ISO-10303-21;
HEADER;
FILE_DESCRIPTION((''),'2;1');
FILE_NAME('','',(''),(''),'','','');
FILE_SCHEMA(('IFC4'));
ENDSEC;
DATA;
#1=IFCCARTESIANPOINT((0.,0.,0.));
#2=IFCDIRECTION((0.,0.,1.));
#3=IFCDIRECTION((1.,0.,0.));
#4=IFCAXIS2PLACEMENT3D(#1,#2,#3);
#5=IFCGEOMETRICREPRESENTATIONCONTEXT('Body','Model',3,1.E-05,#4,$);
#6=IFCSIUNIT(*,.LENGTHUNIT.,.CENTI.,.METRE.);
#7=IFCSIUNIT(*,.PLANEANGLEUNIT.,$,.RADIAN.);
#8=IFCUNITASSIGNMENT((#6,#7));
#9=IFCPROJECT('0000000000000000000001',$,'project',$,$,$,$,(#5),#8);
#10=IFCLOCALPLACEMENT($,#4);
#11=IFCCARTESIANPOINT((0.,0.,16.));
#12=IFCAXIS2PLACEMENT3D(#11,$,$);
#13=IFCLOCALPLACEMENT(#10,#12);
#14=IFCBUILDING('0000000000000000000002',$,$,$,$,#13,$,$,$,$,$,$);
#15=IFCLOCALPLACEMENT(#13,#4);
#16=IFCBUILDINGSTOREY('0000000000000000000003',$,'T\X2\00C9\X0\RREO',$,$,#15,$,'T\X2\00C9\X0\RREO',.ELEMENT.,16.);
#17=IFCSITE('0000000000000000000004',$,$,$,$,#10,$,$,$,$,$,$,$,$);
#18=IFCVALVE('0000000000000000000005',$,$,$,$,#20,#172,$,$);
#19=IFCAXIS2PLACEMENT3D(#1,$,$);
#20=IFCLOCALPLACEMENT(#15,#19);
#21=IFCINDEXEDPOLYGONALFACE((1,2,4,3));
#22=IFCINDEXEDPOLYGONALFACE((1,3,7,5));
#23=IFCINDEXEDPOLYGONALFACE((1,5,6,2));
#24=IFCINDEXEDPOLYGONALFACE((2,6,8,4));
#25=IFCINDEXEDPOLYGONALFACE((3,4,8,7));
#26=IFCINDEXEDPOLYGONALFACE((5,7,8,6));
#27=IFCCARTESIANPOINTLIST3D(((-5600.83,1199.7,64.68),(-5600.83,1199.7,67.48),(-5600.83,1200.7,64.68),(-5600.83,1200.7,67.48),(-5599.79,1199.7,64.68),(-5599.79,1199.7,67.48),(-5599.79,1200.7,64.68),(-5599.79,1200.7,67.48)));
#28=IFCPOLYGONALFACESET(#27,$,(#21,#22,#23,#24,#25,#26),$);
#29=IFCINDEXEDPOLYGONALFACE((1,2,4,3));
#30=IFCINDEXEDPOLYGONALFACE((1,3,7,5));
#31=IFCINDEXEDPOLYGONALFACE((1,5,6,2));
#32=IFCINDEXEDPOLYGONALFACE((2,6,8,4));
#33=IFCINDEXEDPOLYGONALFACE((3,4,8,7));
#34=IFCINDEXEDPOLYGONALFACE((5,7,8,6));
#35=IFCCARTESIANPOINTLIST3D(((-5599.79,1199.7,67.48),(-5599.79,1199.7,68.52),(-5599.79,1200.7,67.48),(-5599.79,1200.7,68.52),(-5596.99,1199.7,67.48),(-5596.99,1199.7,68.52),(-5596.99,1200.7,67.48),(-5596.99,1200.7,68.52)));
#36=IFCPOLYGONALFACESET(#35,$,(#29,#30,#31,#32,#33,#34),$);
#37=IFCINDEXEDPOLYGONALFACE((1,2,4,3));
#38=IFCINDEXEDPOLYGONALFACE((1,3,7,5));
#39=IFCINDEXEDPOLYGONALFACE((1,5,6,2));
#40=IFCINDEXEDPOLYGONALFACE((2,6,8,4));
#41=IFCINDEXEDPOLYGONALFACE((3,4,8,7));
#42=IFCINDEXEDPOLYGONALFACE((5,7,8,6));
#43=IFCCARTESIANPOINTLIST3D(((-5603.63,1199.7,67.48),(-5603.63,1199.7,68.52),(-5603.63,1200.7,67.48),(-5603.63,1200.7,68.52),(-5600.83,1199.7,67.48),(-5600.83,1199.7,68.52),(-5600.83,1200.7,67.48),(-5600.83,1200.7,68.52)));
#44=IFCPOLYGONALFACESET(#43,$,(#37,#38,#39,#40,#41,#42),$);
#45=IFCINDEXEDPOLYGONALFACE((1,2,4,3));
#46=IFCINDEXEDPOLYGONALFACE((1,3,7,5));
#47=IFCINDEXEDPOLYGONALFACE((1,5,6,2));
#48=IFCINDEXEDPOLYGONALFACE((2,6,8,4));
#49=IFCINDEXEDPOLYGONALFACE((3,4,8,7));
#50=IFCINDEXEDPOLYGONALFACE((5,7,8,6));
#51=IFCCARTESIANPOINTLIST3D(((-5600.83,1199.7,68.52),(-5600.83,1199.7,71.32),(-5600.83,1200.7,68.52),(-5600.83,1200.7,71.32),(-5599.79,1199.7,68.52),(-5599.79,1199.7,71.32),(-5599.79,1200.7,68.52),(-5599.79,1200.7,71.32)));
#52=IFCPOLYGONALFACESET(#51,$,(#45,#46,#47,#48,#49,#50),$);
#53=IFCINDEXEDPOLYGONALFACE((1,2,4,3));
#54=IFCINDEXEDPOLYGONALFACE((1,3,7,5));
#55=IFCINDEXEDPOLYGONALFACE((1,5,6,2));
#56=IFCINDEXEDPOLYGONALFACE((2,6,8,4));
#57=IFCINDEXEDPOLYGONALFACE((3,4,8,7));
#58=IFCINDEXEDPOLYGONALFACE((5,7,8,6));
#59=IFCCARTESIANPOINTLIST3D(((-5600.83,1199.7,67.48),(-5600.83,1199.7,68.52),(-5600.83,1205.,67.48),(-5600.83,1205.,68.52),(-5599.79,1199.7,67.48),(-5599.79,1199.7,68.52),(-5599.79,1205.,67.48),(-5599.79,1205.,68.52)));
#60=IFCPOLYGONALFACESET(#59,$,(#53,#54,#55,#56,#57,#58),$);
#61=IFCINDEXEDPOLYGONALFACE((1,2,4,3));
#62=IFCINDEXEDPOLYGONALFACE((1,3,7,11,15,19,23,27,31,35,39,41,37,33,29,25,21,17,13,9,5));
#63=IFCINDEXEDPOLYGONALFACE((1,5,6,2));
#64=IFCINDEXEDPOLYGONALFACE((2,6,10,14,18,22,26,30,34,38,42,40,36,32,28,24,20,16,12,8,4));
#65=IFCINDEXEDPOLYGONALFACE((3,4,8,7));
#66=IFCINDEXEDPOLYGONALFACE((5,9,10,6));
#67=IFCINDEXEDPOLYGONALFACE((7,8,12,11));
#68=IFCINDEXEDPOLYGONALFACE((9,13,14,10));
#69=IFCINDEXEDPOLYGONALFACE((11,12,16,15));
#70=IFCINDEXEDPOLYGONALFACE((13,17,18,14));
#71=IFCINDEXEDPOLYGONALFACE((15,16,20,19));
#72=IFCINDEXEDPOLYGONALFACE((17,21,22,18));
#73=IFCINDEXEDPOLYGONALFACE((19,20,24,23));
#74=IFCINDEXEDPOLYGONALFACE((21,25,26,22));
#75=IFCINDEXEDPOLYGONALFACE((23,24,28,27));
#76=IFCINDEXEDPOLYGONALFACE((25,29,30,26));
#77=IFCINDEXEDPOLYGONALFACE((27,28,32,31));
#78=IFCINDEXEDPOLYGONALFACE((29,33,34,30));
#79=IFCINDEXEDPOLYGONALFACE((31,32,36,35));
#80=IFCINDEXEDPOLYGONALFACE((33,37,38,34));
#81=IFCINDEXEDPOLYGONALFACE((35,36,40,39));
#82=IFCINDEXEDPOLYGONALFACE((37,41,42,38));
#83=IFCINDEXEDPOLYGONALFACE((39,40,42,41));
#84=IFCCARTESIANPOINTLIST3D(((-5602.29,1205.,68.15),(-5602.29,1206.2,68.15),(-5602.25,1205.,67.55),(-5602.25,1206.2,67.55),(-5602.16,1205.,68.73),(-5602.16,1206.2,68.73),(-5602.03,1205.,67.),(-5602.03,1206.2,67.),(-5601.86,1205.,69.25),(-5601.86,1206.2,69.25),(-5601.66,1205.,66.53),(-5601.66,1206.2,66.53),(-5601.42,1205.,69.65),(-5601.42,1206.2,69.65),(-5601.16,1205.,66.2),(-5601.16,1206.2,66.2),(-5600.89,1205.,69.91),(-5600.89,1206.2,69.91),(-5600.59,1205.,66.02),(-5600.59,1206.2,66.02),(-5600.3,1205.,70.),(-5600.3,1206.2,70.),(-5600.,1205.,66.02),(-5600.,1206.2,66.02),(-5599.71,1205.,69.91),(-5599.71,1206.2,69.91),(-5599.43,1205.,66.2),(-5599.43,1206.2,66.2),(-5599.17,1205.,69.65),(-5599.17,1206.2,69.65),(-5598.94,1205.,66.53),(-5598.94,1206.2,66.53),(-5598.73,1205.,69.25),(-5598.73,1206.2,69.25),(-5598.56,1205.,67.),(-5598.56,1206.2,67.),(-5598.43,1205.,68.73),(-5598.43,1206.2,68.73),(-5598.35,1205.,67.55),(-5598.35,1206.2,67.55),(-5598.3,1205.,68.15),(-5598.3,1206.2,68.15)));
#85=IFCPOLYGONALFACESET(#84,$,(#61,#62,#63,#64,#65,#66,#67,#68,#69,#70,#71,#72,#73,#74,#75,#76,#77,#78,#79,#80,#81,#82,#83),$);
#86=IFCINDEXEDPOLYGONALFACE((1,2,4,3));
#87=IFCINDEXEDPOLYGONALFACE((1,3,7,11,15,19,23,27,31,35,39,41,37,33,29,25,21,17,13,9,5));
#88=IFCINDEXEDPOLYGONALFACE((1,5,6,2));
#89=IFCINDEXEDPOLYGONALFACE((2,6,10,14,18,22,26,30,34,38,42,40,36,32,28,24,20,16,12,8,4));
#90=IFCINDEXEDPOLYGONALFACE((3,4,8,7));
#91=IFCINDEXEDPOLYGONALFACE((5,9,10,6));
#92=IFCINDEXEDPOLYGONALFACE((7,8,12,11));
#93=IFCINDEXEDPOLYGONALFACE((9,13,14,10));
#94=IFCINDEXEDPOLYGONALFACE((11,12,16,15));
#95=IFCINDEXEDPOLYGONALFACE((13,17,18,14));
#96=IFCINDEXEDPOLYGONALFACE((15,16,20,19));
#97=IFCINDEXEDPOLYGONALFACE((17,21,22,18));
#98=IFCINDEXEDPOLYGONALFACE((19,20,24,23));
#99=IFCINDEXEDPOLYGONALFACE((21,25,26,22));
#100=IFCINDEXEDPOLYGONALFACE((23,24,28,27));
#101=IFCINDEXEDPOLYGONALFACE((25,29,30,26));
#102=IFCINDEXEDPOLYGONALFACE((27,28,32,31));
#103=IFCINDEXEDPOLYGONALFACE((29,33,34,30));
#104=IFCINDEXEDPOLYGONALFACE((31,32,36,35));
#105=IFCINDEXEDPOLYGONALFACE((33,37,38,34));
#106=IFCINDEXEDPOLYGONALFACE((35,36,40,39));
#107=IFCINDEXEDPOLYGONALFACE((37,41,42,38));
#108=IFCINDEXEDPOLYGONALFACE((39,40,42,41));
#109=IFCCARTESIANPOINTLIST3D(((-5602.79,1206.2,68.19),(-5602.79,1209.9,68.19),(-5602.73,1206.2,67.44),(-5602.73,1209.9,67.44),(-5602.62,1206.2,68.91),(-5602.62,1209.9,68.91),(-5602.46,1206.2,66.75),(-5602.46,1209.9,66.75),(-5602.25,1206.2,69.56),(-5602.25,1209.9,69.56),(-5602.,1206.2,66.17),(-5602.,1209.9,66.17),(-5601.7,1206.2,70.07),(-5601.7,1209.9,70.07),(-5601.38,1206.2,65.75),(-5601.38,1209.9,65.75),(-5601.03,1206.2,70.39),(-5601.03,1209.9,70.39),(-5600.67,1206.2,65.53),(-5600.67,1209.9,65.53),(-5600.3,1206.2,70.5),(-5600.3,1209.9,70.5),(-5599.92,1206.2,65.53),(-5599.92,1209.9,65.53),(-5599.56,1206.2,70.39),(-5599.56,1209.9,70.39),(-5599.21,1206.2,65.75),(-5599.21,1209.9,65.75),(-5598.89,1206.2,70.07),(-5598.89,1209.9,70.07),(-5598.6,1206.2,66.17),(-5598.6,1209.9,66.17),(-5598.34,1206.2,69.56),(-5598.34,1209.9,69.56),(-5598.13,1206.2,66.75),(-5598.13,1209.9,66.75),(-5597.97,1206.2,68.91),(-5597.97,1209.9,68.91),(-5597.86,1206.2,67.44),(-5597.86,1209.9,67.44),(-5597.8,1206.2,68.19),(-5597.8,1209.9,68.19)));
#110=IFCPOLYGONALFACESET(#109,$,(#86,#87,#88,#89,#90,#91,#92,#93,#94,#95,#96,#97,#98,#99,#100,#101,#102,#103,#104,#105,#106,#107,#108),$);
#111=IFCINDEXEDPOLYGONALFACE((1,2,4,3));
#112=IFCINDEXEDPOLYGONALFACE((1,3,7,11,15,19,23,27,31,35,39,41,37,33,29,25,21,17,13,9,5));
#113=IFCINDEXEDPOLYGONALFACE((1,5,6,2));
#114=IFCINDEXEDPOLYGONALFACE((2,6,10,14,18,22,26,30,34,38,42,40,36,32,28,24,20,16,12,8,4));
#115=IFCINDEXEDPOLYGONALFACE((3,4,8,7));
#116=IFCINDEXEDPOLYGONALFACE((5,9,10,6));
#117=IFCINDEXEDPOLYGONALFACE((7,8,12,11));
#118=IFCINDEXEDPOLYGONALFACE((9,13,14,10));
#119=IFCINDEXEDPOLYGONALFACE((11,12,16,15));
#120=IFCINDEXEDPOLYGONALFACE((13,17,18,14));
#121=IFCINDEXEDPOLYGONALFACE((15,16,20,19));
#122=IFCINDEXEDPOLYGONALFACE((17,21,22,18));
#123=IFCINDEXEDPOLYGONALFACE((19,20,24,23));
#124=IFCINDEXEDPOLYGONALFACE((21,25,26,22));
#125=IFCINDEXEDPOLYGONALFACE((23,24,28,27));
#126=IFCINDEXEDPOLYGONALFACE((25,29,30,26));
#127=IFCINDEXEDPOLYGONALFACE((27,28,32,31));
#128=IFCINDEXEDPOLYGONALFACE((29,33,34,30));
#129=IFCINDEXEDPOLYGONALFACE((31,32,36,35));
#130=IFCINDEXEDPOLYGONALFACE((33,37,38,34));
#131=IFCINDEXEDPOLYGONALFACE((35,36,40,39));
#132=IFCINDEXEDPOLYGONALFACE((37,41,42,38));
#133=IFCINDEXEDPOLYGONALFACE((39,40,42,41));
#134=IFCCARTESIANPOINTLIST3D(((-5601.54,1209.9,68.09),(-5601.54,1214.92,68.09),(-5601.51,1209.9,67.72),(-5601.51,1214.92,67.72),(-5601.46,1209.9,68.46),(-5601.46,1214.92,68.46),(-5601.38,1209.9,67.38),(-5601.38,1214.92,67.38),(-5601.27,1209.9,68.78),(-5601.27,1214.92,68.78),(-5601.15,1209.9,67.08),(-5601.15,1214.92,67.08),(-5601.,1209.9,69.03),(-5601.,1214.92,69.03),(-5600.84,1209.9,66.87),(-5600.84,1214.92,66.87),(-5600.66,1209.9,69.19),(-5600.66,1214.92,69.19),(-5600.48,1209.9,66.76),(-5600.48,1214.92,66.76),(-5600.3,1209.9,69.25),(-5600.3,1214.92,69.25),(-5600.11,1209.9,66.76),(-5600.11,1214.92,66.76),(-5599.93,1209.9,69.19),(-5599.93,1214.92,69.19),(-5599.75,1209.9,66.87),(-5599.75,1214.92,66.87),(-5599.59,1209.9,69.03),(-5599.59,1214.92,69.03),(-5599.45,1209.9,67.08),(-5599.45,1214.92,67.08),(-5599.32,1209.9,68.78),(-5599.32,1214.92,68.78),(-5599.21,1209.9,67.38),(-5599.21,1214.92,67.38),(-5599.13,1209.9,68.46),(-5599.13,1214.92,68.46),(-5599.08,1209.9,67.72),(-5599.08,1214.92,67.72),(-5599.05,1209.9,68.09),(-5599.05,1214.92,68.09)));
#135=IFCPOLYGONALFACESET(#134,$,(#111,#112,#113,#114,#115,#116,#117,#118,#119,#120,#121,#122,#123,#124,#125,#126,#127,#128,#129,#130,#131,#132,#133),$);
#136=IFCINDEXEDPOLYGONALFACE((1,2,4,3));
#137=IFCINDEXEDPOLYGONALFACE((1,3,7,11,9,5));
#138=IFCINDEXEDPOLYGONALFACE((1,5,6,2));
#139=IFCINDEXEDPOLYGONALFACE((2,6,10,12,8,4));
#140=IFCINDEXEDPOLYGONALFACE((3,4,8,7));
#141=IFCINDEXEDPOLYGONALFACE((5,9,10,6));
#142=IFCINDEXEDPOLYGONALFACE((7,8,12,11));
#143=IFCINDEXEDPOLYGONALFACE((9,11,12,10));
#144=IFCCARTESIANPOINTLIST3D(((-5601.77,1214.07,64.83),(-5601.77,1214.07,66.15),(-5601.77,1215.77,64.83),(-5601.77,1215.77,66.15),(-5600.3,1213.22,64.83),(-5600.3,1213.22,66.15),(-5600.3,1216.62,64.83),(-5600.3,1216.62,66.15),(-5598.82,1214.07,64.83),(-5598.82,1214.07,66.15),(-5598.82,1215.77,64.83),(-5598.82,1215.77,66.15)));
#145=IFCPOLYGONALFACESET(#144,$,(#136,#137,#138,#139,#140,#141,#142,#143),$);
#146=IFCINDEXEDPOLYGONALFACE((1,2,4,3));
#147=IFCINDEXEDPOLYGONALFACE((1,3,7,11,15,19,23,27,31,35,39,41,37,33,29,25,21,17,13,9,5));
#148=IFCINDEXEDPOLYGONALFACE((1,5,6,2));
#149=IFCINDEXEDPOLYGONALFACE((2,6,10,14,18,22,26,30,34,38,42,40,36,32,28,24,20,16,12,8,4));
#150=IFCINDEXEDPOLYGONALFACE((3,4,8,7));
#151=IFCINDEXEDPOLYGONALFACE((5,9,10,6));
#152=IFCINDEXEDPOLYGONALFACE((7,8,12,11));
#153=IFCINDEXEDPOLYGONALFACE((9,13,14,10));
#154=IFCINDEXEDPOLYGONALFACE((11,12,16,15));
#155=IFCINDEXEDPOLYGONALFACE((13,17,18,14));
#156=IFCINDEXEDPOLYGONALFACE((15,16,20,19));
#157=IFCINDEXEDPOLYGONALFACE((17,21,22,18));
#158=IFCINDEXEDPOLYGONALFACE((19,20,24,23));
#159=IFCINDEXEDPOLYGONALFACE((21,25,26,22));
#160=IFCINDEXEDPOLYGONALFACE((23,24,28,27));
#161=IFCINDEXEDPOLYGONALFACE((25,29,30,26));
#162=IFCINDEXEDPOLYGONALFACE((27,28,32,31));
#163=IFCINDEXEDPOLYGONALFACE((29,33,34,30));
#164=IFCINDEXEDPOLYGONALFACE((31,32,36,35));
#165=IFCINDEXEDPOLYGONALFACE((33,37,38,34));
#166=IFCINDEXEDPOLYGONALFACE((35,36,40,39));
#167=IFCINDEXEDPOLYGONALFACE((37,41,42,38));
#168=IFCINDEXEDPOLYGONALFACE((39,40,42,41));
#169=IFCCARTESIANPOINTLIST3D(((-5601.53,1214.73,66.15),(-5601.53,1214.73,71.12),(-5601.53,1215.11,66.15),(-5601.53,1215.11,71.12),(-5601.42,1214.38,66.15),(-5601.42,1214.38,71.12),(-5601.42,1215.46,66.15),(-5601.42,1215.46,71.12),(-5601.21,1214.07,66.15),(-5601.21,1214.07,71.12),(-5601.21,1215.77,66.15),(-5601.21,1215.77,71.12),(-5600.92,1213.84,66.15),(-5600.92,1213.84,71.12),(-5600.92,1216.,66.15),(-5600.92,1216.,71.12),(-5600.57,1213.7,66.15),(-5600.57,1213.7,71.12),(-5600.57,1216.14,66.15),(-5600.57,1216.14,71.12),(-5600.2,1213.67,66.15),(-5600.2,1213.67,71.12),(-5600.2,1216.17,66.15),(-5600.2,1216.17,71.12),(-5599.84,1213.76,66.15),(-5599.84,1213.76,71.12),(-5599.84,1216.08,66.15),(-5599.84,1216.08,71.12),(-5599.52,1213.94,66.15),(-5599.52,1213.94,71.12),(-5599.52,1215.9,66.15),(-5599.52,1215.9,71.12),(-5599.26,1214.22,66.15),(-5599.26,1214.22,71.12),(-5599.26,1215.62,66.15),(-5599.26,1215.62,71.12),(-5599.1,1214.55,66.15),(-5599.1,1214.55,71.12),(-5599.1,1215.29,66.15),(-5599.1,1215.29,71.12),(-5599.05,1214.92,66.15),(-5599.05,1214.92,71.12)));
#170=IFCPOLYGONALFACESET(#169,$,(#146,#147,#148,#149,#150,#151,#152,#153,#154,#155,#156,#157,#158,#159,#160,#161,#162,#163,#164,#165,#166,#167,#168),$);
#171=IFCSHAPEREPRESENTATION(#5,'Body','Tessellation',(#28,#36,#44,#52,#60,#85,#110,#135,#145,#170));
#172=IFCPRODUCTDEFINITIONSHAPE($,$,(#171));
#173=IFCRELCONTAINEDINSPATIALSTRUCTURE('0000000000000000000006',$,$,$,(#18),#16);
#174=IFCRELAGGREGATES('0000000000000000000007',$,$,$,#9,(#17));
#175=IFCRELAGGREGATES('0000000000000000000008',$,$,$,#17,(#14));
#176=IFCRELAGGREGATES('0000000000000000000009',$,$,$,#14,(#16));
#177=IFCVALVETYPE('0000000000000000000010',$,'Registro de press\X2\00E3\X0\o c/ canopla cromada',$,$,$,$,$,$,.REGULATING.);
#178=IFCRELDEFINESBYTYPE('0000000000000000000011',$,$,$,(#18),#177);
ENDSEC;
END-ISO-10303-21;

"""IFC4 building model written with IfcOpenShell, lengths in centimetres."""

from ifc_helpers import new_model, si_unit, frame, origin_with_axes, origin_2d_with_axis, place, context, project, spatial, polyline, rectangle, circle, outline, extrude, source, transform, mapped, type_object, element, save


model = new_model("IFC4")

# Units and contexts
model_context = context("Model", 3, precision=1e-05, world=origin_with_axes(), identifier="Body")
ifc_project = project(units=[si_unit("LENGTHUNIT", "METRE", prefix="CENTI"), si_unit("PLANEANGLEUNIT", "RADIAN")], contexts=[model_context])

# Site, building, storey
site_placement = place(None, origin_with_axes())
site = spatial("IfcSite", under=ifc_project, at=site_placement)
building_placement = place(site_placement, frame((0.0, 0.0, 16.0)))
building = spatial("IfcBuilding", under=site, at=building_placement)
storey_placement = place(building_placement, origin_with_axes())
storey = spatial("IfcBuildingStorey", under=building, at=storey_placement, Name="TÉRREO", LongName="TÉRREO", CompositionType="ELEMENT", Elevation=16.0)

# Valve
valve_type = type_object("IfcValveType", Name="Registro de pressão c/ canopla cromada", PredefinedType="REGULATING")
shared_shape = source(origin_with_axes(), model_context, "Body", "SolidModel", [
    extrude(rectangle(XDim=1.04, YDim=2.8, at=origin_2d_with_axis()), frame((-1.92, 0.01, 14.22), z_axis=(0.0, 0.0, 1.0), x_axis=(0.0, -1.0, 0.0)), (0.0, 0.0, 1.0), 1.0),
    extrude(rectangle(XDim=1.04, YDim=2.8, at=origin_2d_with_axis()), frame((0.0, -1.91, 14.22), z_axis=(0.0, 0.0, 1.0), x_axis=(1.0, 0.0, 0.0)), (0.0, 0.0, 1.0), 1.0),
    extrude(rectangle(XDim=1.04, YDim=2.8, at=origin_2d_with_axis()), frame((0.0, 1.93, 14.22), z_axis=(0.0, 0.0, 1.0), x_axis=(-1.0, 0.0, 0.0)), (0.0, 0.0, 1.0), 1.0),
    extrude(rectangle(XDim=1.04, YDim=2.8, at=origin_2d_with_axis()), frame((1.92, 0.01, 14.22), z_axis=(0.0, 0.0, 1.0), x_axis=(0.0, 1.0, 0.0)), (0.0, 0.0, 1.0), 1.0),
    extrude(rectangle(XDim=1.04, YDim=1.04, at=origin_2d_with_axis()), frame((0.0, 0.01, 9.92), z_axis=(0.0, 0.0, 1.0), x_axis=(0.0, 1.0, 0.0)), (0.0, 0.0, 1.0), 5.3),
    extrude(circle(Radius=2.0, at=origin_2d_with_axis()), frame((0.0, 0.0, 8.72), z_axis=(0.0, 0.0, 1.0), x_axis=(1.0, 0.0, 0.0)), (0.0, 0.0, 1.0), 1.2),
    extrude(circle(Radius=2.5, at=origin_2d_with_axis()), frame((0.0, 0.0, 5.02), z_axis=(0.0, 0.0, 1.0), x_axis=(1.0, 0.0, 0.0)), (0.0, 0.0, 1.0), 3.7),
    extrude(circle(Radius=1.25, at=origin_2d_with_axis()), origin_with_axes(), (0.0, 0.0, 1.0), 5.02),
    extrude(outline(polyline([(-0.85, -1.47), (0.85, -1.47), (1.7, 0.0), (0.85, 1.47), (-0.85, 1.47), (-1.7, 0.0), (-0.85, -1.47)])), frame((-3.17, 0.0, 0.0), z_axis=(1.0, 0.0, 0.0), x_axis=(0.0, 0.0, -1.0)), (0.0, 0.0, 1.0), 1.32),
    extrude(circle(Radius=1.25, at=origin_2d_with_axis()), frame((-1.85, 0.0, 0.0), z_axis=(1.0, 0.0, 0.0), x_axis=(0.0, -1.0, 0.0)), (0.0, 0.0, 1.0), 4.97),
])
for number, where, z_axis, x_axis in (
    (1, (-5600.3, 1214.92, 68.0), (0.0, -1.0, 0.0), (0.0, 0.0, 1.0)),
):
    element("IfcValve", number, at=place(storey_placement, frame(where, z_axis=z_axis, x_axis=x_axis)), inside=storey, type_object=valve_type, context=model_context, shape_type="MappedRepresentation", body=[
        mapped(shared_shape, transform((0.0, 0.0, 0.0), scale=1.0)),
    ])

save(model, "model.ifc")
